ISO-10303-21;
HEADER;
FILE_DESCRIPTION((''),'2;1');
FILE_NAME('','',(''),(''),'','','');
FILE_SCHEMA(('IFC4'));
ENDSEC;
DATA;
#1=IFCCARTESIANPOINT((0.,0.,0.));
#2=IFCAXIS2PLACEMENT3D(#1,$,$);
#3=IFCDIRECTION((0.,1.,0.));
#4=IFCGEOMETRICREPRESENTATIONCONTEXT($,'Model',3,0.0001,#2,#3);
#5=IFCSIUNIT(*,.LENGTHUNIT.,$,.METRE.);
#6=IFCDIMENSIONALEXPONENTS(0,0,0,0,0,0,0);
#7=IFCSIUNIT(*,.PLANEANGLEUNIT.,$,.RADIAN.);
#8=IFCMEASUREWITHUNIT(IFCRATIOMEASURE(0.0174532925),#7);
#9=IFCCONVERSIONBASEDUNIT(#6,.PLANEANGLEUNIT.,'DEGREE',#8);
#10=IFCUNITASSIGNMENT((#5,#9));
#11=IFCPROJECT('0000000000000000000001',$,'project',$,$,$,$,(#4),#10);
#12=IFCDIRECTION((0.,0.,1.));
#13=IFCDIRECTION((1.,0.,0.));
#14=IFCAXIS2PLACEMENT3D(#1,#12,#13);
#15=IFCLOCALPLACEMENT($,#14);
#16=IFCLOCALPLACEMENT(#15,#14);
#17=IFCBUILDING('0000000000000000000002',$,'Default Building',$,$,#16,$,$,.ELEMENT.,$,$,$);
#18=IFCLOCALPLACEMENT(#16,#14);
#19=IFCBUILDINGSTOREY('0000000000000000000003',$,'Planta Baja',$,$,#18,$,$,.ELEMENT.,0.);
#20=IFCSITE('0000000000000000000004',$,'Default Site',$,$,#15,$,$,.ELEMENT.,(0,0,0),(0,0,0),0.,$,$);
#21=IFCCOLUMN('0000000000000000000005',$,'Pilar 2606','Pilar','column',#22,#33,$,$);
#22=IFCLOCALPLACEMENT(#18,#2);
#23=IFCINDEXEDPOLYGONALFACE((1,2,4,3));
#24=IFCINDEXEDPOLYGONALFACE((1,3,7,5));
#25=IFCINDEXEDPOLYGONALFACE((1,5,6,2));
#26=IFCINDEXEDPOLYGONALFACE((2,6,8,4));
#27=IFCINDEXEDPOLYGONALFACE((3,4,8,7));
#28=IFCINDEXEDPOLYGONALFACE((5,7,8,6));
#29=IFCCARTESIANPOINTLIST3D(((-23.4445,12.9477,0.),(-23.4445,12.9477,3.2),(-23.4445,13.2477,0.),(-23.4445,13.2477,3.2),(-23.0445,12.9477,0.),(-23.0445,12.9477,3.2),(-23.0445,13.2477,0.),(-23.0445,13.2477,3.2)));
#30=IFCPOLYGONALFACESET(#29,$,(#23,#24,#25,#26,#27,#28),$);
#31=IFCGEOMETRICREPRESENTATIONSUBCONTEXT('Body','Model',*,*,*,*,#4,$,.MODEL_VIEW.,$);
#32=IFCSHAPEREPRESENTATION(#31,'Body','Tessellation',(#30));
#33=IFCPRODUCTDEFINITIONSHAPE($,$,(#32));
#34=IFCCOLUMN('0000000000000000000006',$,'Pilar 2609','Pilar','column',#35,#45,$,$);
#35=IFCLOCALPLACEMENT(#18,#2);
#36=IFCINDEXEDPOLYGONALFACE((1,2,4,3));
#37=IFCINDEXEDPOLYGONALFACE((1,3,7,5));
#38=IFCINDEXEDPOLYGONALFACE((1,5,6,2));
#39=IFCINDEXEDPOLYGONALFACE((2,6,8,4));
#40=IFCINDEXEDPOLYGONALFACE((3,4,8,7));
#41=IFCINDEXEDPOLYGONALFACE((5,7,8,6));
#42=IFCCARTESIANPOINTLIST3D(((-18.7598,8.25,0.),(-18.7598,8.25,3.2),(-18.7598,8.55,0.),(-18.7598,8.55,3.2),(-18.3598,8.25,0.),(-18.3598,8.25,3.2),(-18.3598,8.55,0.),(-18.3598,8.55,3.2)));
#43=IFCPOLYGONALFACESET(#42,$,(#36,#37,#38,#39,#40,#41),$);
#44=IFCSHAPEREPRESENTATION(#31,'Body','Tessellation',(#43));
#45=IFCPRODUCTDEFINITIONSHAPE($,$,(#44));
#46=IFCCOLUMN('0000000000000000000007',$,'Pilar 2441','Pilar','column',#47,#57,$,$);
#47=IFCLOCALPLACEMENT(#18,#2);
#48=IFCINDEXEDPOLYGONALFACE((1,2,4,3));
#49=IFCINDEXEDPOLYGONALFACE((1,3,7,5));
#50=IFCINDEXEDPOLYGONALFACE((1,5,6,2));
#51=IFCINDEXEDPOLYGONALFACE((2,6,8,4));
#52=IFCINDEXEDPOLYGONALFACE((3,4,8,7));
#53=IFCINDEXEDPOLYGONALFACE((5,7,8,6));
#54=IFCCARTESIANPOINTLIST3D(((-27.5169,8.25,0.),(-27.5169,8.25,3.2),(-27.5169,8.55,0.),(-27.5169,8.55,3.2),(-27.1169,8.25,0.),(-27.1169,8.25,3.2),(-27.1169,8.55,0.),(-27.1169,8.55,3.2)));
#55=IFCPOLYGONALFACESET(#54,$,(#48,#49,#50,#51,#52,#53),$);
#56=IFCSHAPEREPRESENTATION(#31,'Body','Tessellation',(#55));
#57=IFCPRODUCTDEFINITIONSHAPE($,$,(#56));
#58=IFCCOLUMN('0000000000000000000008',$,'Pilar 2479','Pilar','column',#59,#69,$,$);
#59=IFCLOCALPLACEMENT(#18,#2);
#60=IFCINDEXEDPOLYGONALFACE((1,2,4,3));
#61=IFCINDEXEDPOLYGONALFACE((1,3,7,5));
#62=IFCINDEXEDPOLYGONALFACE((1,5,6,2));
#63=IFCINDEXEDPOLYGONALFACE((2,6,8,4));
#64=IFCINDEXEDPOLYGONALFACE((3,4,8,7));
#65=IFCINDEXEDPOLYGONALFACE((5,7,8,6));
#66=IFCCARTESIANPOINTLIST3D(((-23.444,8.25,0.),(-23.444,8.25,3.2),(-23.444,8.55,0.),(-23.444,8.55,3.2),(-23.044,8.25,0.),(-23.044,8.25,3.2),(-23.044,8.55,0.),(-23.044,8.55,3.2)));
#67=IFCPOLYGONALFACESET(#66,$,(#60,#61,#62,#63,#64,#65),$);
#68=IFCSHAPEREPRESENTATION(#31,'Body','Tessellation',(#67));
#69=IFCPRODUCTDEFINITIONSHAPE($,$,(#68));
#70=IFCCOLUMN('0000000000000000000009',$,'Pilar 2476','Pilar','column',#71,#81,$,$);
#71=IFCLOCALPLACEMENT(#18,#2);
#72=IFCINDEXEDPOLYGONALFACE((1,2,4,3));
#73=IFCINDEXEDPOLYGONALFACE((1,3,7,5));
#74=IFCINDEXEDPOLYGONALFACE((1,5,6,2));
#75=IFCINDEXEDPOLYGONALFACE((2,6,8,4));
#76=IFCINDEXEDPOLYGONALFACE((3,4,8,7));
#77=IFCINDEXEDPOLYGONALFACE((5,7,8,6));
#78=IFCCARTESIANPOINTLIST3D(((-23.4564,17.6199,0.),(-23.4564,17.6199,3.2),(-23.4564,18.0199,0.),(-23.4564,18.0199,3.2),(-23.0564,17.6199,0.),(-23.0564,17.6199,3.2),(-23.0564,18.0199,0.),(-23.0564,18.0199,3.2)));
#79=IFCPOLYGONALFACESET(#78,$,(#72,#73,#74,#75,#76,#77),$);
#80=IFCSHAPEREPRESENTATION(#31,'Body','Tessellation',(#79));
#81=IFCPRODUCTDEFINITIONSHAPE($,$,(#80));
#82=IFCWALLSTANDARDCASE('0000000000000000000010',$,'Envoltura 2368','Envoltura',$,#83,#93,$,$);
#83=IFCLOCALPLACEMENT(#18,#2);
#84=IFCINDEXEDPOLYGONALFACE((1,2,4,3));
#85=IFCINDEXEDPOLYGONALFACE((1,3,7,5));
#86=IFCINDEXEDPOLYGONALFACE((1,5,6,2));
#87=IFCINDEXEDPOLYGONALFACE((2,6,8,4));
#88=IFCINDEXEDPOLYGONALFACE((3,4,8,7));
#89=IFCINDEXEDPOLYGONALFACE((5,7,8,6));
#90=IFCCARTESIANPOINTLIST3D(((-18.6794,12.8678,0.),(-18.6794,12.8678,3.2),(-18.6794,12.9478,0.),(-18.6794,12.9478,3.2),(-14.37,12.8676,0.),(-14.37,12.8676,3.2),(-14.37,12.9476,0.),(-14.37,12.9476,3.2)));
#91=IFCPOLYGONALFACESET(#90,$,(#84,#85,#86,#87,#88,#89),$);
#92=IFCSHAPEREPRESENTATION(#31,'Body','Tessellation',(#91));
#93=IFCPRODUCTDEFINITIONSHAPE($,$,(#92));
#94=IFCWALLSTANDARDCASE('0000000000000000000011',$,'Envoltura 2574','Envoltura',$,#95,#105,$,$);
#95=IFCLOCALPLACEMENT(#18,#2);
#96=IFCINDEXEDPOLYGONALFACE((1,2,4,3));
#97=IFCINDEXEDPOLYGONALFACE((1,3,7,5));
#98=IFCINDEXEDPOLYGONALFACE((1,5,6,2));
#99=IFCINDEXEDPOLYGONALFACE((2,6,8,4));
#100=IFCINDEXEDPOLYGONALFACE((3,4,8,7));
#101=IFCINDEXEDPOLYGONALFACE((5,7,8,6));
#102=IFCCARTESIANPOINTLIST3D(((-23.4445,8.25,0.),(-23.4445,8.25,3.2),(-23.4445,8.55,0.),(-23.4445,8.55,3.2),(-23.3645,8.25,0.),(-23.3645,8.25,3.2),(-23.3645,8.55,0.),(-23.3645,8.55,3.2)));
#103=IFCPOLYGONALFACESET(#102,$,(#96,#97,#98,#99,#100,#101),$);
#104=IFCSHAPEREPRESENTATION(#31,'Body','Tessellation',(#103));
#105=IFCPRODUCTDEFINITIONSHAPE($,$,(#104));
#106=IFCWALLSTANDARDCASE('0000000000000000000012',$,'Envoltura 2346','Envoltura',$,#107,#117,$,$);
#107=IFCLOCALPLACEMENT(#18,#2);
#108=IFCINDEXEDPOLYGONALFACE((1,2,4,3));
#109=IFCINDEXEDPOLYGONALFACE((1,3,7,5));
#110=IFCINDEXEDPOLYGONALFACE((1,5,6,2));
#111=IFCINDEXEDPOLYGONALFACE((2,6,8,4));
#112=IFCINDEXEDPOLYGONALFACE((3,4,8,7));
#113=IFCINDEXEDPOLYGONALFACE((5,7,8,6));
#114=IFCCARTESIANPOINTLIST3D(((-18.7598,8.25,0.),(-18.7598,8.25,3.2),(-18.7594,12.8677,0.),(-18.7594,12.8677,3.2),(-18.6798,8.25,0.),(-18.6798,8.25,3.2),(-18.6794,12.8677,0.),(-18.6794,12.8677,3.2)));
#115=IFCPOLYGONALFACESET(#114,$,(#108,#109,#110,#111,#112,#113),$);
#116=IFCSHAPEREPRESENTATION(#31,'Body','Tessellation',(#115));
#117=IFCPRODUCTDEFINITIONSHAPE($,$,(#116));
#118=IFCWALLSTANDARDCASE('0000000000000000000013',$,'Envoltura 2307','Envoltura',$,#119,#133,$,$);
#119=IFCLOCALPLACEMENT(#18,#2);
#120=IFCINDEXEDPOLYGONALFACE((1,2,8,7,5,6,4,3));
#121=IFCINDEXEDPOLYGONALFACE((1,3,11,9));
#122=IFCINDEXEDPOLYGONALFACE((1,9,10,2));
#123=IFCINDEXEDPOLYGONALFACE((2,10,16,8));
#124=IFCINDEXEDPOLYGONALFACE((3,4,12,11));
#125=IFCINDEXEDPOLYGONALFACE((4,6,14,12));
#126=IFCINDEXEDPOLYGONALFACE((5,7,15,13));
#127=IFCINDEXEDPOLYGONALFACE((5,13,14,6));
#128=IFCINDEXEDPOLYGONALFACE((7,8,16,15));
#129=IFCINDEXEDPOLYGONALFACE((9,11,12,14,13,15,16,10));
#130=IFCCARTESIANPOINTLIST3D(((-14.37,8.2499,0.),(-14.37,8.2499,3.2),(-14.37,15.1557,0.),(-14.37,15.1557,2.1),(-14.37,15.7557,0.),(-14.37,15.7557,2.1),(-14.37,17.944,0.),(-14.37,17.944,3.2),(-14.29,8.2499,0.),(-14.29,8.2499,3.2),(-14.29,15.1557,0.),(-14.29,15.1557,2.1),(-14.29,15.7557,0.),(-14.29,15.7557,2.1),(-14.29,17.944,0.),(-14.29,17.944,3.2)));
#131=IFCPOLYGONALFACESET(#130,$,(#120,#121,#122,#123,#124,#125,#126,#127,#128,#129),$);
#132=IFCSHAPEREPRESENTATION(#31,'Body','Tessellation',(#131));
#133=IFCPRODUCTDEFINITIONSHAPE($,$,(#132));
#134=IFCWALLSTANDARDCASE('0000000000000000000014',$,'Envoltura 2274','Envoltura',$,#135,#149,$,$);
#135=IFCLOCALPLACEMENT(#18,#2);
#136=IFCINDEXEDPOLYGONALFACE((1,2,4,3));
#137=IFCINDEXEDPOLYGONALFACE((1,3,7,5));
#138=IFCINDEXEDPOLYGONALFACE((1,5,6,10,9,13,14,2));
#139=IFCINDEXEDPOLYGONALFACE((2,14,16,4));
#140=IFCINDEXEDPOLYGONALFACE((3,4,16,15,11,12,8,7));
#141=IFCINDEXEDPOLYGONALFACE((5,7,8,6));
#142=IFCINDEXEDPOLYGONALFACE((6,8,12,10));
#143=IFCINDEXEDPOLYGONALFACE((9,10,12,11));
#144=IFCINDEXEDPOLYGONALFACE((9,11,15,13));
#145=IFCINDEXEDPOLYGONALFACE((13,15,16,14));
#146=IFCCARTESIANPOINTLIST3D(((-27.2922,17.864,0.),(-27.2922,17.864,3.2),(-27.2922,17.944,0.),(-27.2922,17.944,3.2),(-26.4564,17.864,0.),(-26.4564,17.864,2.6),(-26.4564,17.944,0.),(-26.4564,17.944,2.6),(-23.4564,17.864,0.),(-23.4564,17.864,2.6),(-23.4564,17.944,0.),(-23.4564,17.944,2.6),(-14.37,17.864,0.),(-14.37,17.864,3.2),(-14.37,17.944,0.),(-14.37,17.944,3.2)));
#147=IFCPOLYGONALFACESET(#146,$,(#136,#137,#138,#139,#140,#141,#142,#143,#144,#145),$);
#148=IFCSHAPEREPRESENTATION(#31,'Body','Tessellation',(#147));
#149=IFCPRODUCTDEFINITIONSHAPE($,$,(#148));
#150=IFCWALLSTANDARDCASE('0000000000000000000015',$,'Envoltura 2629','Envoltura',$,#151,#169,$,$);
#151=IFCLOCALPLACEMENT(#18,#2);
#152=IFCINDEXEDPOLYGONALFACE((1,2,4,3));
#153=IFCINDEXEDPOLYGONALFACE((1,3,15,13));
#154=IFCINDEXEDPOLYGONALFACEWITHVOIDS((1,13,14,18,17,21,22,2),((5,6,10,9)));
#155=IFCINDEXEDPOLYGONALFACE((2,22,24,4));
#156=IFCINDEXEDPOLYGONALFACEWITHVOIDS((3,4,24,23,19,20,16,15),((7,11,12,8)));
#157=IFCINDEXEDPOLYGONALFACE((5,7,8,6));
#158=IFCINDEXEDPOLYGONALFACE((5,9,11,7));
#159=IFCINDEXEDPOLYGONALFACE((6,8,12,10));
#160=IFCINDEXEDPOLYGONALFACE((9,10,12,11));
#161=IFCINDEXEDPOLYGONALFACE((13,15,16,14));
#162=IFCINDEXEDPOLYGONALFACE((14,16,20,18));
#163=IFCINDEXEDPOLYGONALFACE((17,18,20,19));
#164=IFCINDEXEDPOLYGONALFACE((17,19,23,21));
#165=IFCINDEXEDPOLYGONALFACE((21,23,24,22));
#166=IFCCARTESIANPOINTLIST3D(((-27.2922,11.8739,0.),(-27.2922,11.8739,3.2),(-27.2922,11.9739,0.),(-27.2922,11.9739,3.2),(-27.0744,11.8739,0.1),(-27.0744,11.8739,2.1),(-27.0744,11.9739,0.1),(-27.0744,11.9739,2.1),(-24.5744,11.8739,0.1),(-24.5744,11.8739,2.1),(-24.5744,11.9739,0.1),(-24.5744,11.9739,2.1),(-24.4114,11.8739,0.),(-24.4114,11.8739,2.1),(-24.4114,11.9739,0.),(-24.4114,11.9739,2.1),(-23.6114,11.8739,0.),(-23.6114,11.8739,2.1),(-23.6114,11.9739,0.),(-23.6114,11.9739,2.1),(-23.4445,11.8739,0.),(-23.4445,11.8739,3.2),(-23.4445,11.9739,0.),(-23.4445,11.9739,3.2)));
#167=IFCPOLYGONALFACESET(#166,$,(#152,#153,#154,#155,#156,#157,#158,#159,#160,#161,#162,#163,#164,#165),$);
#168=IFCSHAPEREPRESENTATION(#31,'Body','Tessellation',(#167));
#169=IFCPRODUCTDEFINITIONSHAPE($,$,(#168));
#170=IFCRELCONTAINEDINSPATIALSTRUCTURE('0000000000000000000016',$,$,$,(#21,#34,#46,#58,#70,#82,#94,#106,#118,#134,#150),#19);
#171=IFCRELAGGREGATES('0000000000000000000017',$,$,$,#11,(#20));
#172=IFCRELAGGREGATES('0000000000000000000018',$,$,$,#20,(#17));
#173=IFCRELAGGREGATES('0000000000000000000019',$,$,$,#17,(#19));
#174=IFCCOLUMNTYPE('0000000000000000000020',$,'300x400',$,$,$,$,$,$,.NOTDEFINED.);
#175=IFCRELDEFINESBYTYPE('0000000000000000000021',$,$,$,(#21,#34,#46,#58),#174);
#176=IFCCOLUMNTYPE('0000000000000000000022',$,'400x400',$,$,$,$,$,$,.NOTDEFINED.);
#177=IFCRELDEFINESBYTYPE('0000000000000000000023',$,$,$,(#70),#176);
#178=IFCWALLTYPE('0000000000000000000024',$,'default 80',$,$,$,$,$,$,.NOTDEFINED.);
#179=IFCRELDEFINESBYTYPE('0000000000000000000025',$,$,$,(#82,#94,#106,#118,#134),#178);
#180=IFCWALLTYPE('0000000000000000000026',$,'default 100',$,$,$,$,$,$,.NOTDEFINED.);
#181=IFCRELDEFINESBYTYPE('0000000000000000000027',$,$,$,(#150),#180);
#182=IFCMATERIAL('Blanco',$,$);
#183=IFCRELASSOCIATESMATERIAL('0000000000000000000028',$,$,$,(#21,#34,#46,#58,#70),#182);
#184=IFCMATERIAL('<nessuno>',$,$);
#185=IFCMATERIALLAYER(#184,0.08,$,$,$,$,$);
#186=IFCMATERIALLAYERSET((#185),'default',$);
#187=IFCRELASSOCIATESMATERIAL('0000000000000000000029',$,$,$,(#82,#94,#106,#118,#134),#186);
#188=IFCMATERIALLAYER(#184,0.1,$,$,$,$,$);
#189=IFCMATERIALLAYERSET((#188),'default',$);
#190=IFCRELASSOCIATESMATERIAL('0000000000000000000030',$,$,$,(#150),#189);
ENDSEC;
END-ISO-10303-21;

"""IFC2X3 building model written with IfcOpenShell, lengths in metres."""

from ifc_helpers import new_model, entity, si_unit, converted_unit, direction, frame, origin, origin_with_axes, origin_2d_with_axis, place, context, subcontext, project, spatial, polyline, rectangle, outline, extrude, source, transform, mapped, material, layer, layer_set, layer_usage, type_object, element, save


model = new_model("IFC2X3")

# Units and contexts
model_context = context("Model", 3, precision=0.0001, world=origin(), true_north=direction((0.0, 1.0, 0.0)))
body_context = subcontext(model_context, "Body", "Model", "MODEL_VIEW")
ifc_project = project(units=[si_unit("LENGTHUNIT", "METRE"), converted_unit("PLANEANGLEUNIT", "DEGREE", entity("IfcRatioMeasure", 0.0174532925), si_unit("PLANEANGLEUNIT", "RADIAN"), dimensions=[0, 0, 0, 0, 0, 0, 0])], contexts=[model_context])

# Site, building, storey
site_placement = place(None, origin_with_axes())
site = spatial("IfcSite", under=ifc_project, at=site_placement, Name="Default Site", CompositionType="ELEMENT", RefLatitude=(0, 0, 0), RefLongitude=(0, 0, 0), RefElevation=0.0)
building_placement = place(site_placement, origin_with_axes())
building = spatial("IfcBuilding", under=site, at=building_placement, Name="Default Building", CompositionType="ELEMENT")
storey_placement = place(building_placement, origin_with_axes())
storey = spatial("IfcBuildingStorey", under=building, at=storey_placement, Name="Planta Baja", CompositionType="ELEMENT", Elevation=0.0)

# Columns
ifc_material_1 = material(Name="Blanco")
column_type_1 = type_object("IfcColumnType", Name="300x400", PredefinedType="NOTDEFINED")
shared_shape_1 = source(origin_with_axes(), body_context, "Body", "SweptSolid", [
    extrude(rectangle(XDim=0.3, YDim=0.4, at=origin_2d_with_axis()), origin_with_axes(), (0.0, 0.0, 1.0), 1.0),
])
for number, where, z_axis, x_axis, name in (
    (1, (-23.4445, 12.9477, 0.0), (0.0, 0.0, 1.0), (0.0, -1.0, 0.0), "Pilar 2606"),
    (2, (-18.7598, 8.25, 0.0), (0.0, 0.0, 1.0), (0.0, -1.0, 0.0), "Pilar 2609"),
):
    element("IfcColumn", number, at=place(storey_placement, frame(where, z_axis=z_axis, x_axis=x_axis)), inside=storey, type_object=column_type_1, material=ifc_material_1, Name=name, Description="Pilar", ObjectType="column", context=body_context, shape_type="MappedRepresentation", body=[
        mapped(shared_shape_1, transform((-0.15, 0.2, 0.0), x_axis=(1.0, 0.0, 0.0), y_axis=(0.0, 1.0, 0.0), z_axis=(0.0, 0.0, 1.0), scale=1.0, scale2=1.0, scale3=3.2, uniform=False)),
    ])
column_1_placement = place(storey_placement, frame((-27.5169, 8.25, 0.0), z_axis=(0.0, 0.0, 1.0), x_axis=(0.0, -1.0, 0.0)))
element("IfcColumn", 3, at=column_1_placement, inside=storey, type_object=column_type_1, material=ifc_material_1, Name="Pilar 2441", Description="Pilar", ObjectType="column", context=body_context, shape_type="MappedRepresentation", body=[
    mapped(shared_shape_1, transform((-0.15, 0.2, 0.0), x_axis=(1.0, 0.0, 0.0), y_axis=(0.0, 1.0, 0.0), z_axis=(0.0, 0.0, 1.0), scale=1.0, scale2=1.0, scale3=3.2, uniform=False)),
])
column_2_placement = place(storey_placement, frame((-23.444, 8.25, 0.0), z_axis=(0.0, 0.0, 1.0), x_axis=(0.0, -1.0, 0.0)))
element("IfcColumn", 4, at=column_2_placement, inside=storey, type_object=column_type_1, material=ifc_material_1, Name="Pilar 2479", Description="Pilar", ObjectType="column", context=body_context, shape_type="MappedRepresentation", body=[
    mapped(shared_shape_1, transform((-0.15, 0.2, 0.0), x_axis=(1.0, 0.0, 0.0), y_axis=(0.0, 1.0, 0.0), z_axis=(0.0, 0.0, 1.0), scale=1.0, scale2=1.0, scale3=3.2, uniform=False)),
])
column_type_2 = type_object("IfcColumnType", Name="400x400", PredefinedType="NOTDEFINED")
shared_shape_2 = source(origin_with_axes(), body_context, "Body", "SweptSolid", [
    extrude(rectangle(XDim=0.4, YDim=0.4, at=origin_2d_with_axis()), origin_with_axes(), (0.0, 0.0, 1.0), 1.0),
])
column_3_placement = place(storey_placement, frame((-23.0564, 17.6199, 0.0), z_axis=(0.0, 0.0, 1.0), x_axis=(1.0, 0.0, 0.0)))
element("IfcColumn", 5, at=column_3_placement, inside=storey, type_object=column_type_2, material=ifc_material_1, Name="Pilar 2476", Description="Pilar", ObjectType="column", context=body_context, shape_type="MappedRepresentation", body=[
    mapped(shared_shape_2, transform((-0.2, 0.2, 0.0), x_axis=(1.0, 0.0, 0.0), y_axis=(0.0, 1.0, 0.0), z_axis=(0.0, 0.0, 1.0), scale=1.0, scale2=1.0, scale3=3.2, uniform=False)),
])

# Walls
ifc_material_2 = material(Name="<nessuno>")
ifc_layer_1 = layer(ifc_material_2, 0.08)
ifc_layer_set_1 = layer_set([ifc_layer_1], Name="default")
ifc_layer_usage_1 = layer_usage(ifc_layer_set_1, "AXIS2", "POSITIVE", -0.04)
wall_type_1 = type_object("IfcWallType", Name="default 80", PredefinedType="NOTDEFINED")
wall_1_placement = place(storey_placement, frame((-18.7194, 12.9077, 0.0), z_axis=(0.0, 0.0, 1.0), x_axis=(1.0, 0.0, 0.0)))
element("IfcWallStandardCase", 6, at=wall_1_placement, inside=storey, type_object=wall_type_1, material=ifc_layer_usage_1, Name="Envoltura 2368", Description="Envoltura", context=body_context, shape_type="SweptSolid", body=[
    extrude(rectangle(XDim=0.08, YDim=4.3094, at=origin_2d_with_axis()), frame((2.1947, 0.0, 0.0), z_axis=(0.0, 0.0, 1.0), x_axis=(-0.000041, -1.0, 0.0)), (0.0, 0.0, 1.0), 3.2),
])
ifc_layer_usage_2 = layer_usage(ifc_layer_set_1, "AXIS2", "POSITIVE", -0.04)
wall_2_placement = place(storey_placement, frame((-23.4045, 8.25, 0.0), z_axis=(0.0, 0.0, 1.0), x_axis=(0.0, 1.0, 0.0)))
element("IfcWallStandardCase", 7, at=wall_2_placement, inside=storey, type_object=wall_type_1, material=ifc_layer_usage_2, Name="Envoltura 2574", Description="Envoltura", context=body_context, shape_type="SweptSolid", body=[
    extrude(outline(polyline([(0.3, 0.04), (0.0, 0.04), (0.0, -0.04), (0.3, -0.04), (0.3, -0.06), (0.3, 0.04)])), origin_with_axes(), (0.0, 0.0, 1.0), 3.2),
])
ifc_layer_usage_3 = layer_usage(ifc_layer_set_1, "AXIS2", "POSITIVE", -0.04)
wall_3_placement = place(storey_placement, frame((-18.7198, 8.2498, 0.0), z_axis=(0.0, 0.0, 1.0), x_axis=(0.000082, 1.0, 0.0)))
element("IfcWallStandardCase", 8, at=wall_3_placement, inside=storey, type_object=wall_type_1, material=ifc_layer_usage_3, Name="Envoltura 2346", Description="Envoltura", context=body_context, shape_type="SweptSolid", body=[
    extrude(rectangle(XDim=4.6177, YDim=0.08, at=origin_2d_with_axis()), frame((2.309, 0.0, 0.0), z_axis=(0.0, 0.0, 1.0), x_axis=(1.0, 0.0, 0.0)), (0.0, 0.0, 1.0), 3.2),
])

# Walls, openings
ifc_layer_usage_4 = layer_usage(ifc_layer_set_1, "AXIS2", "POSITIVE", -0.04)
wall_4_placement = place(storey_placement, frame((-14.33, 8.2499, 0.0), z_axis=(0.0, 0.0, 1.0), x_axis=(0.0, 1.0, 0.0)))
wall_4 = element("IfcWallStandardCase", 9, at=wall_4_placement, inside=storey, type_object=wall_type_1, material=ifc_layer_usage_4, Name="Envoltura 2307", Description="Envoltura", context=body_context, shape_type="SweptSolid", body=[
    extrude(rectangle(XDim=0.08, YDim=9.6941, at=origin_2d_with_axis()), frame((4.847, 0.0, 0.0), z_axis=(0.0, 0.0, 1.0), x_axis=(0.0, -1.0, 0.0)), (0.0, 0.0, 1.0), 3.2),
])
opening_1_placement = place(wall_4_placement, frame((6.9058, 0.0, 0.0), z_axis=(0.0, 0.0, 1.0), x_axis=(-1.0, 0.0, 0.0)))
element("IfcOpeningElement", 10, at=opening_1_placement, cuts=wall_4, ObjectType="Opening", context=body_context, shape_type="SweptSolid", body=[
    extrude(outline(polyline([(0.0, 2.1), (0.0, 0.0), (0.6, 0.0), (0.6, 2.1), (0.0, 2.1)])), frame((0.0, -0.04, 0.0), z_axis=(0.0, 1.0, 0.0), x_axis=(-1.0, 0.0, 0.0)), (0.0, 0.0, 1.0), 0.08),
])
ifc_layer_usage_5 = layer_usage(ifc_layer_set_1, "AXIS2", "POSITIVE", -0.04)
wall_5_placement = place(storey_placement, frame((-27.2922, 17.904, 0.0), z_axis=(0.0, 0.0, 1.0), x_axis=(1.0, 0.0, 0.0)))
wall_5 = element("IfcWallStandardCase", 11, at=wall_5_placement, inside=storey, type_object=wall_type_1, material=ifc_layer_usage_5, Name="Envoltura 2274", Description="Envoltura", context=body_context, shape_type="SweptSolid", body=[
    extrude(rectangle(XDim=12.9222, YDim=0.08, at=origin_2d_with_axis()), frame((6.4611, 0.0, 0.0), z_axis=(0.0, 0.0, 1.0), x_axis=(1.0, 0.0, 0.0)), (0.0, 0.0, 1.0), 3.2),
])
opening_2_placement = place(wall_5_placement, frame((0.8358, 0.0, 0.0), z_axis=(0.0, 0.0, 1.0), x_axis=(-1.0, 0.0, 0.0)))
element("IfcOpeningElement", 12, at=opening_2_placement, cuts=wall_5, ObjectType="Opening", context=body_context, shape_type="SweptSolid", body=[
    extrude(outline(polyline([(0.0, 2.6), (0.0, 0.0), (3.0, 0.0), (3.0, 2.6), (0.0, 2.6)])), frame((0.0, -0.04, 0.0), z_axis=(0.0, 1.0, 0.0), x_axis=(-1.0, 0.0, 0.0)), (0.0, 0.0, 1.0), 0.08),
])

# Shared definitions
ifc_layer_2 = layer(ifc_material_2, 0.1)
ifc_layer_set_2 = layer_set([ifc_layer_2], Name="default")
wall_type_2 = type_object("IfcWallType", Name="default 100", PredefinedType="NOTDEFINED")

# Wall, openings
ifc_layer_usage_6 = layer_usage(ifc_layer_set_2, "AXIS2", "POSITIVE", -0.05)
wall_6_placement = place(storey_placement, frame((-27.2946, 11.9239, 0.0), z_axis=(0.0, 0.0, 1.0), x_axis=(1.0, 0.0, 0.0)))
wall_6 = element("IfcWallStandardCase", 13, at=wall_6_placement, inside=storey, type_object=wall_type_2, material=ifc_layer_usage_6, Name="Envoltura 2629", Description="Envoltura", context=body_context, shape_type="SweptSolid", body=[
    extrude(rectangle(XDim=0.1, YDim=3.8477, at=origin_2d_with_axis()), frame((1.9262, 0.0, 0.0), z_axis=(0.0, 0.0, 1.0), x_axis=(0.0, -1.0, 0.0)), (0.0, 0.0, 1.0), 3.2),
])
opening_3_placement = place(wall_6_placement, frame((2.8832, 0.0, 0.0), z_axis=(0.0, 0.0, 1.0), x_axis=(-1.0, 0.0, 0.0)))
element("IfcOpeningElement", 14, at=opening_3_placement, cuts=wall_6, ObjectType="Opening", context=body_context, shape_type="SweptSolid", body=[
    extrude(outline(polyline([(0.0, 2.1), (0.0, 0.0), (0.8, 0.0), (0.8, 2.1), (0.0, 2.1)])), frame((0.0, -0.05, 0.0), z_axis=(0.0, 1.0, 0.0), x_axis=(-1.0, 0.0, 0.0)), (0.0, 0.0, 1.0), 0.1),
])
opening_4_placement = place(wall_6_placement, frame((0.2202, 0.0, 0.0), z_axis=(0.0, 0.0, 1.0), x_axis=(-1.0, 0.0, 0.0)))
element("IfcOpeningElement", 15, at=opening_4_placement, cuts=wall_6, ObjectType="Opening", context=body_context, shape_type="SweptSolid", body=[
    extrude(outline(polyline([(0.0, 2.1), (0.0, 0.1), (2.5, 0.1), (2.5, 2.1), (0.0, 2.1)])), frame((0.0, -0.05, 0.0), z_axis=(0.0, 1.0, 0.0), x_axis=(-1.0, 0.0, 0.0)), (0.0, 0.0, 1.0), 0.1),
])

save(model, "model.ifc")
